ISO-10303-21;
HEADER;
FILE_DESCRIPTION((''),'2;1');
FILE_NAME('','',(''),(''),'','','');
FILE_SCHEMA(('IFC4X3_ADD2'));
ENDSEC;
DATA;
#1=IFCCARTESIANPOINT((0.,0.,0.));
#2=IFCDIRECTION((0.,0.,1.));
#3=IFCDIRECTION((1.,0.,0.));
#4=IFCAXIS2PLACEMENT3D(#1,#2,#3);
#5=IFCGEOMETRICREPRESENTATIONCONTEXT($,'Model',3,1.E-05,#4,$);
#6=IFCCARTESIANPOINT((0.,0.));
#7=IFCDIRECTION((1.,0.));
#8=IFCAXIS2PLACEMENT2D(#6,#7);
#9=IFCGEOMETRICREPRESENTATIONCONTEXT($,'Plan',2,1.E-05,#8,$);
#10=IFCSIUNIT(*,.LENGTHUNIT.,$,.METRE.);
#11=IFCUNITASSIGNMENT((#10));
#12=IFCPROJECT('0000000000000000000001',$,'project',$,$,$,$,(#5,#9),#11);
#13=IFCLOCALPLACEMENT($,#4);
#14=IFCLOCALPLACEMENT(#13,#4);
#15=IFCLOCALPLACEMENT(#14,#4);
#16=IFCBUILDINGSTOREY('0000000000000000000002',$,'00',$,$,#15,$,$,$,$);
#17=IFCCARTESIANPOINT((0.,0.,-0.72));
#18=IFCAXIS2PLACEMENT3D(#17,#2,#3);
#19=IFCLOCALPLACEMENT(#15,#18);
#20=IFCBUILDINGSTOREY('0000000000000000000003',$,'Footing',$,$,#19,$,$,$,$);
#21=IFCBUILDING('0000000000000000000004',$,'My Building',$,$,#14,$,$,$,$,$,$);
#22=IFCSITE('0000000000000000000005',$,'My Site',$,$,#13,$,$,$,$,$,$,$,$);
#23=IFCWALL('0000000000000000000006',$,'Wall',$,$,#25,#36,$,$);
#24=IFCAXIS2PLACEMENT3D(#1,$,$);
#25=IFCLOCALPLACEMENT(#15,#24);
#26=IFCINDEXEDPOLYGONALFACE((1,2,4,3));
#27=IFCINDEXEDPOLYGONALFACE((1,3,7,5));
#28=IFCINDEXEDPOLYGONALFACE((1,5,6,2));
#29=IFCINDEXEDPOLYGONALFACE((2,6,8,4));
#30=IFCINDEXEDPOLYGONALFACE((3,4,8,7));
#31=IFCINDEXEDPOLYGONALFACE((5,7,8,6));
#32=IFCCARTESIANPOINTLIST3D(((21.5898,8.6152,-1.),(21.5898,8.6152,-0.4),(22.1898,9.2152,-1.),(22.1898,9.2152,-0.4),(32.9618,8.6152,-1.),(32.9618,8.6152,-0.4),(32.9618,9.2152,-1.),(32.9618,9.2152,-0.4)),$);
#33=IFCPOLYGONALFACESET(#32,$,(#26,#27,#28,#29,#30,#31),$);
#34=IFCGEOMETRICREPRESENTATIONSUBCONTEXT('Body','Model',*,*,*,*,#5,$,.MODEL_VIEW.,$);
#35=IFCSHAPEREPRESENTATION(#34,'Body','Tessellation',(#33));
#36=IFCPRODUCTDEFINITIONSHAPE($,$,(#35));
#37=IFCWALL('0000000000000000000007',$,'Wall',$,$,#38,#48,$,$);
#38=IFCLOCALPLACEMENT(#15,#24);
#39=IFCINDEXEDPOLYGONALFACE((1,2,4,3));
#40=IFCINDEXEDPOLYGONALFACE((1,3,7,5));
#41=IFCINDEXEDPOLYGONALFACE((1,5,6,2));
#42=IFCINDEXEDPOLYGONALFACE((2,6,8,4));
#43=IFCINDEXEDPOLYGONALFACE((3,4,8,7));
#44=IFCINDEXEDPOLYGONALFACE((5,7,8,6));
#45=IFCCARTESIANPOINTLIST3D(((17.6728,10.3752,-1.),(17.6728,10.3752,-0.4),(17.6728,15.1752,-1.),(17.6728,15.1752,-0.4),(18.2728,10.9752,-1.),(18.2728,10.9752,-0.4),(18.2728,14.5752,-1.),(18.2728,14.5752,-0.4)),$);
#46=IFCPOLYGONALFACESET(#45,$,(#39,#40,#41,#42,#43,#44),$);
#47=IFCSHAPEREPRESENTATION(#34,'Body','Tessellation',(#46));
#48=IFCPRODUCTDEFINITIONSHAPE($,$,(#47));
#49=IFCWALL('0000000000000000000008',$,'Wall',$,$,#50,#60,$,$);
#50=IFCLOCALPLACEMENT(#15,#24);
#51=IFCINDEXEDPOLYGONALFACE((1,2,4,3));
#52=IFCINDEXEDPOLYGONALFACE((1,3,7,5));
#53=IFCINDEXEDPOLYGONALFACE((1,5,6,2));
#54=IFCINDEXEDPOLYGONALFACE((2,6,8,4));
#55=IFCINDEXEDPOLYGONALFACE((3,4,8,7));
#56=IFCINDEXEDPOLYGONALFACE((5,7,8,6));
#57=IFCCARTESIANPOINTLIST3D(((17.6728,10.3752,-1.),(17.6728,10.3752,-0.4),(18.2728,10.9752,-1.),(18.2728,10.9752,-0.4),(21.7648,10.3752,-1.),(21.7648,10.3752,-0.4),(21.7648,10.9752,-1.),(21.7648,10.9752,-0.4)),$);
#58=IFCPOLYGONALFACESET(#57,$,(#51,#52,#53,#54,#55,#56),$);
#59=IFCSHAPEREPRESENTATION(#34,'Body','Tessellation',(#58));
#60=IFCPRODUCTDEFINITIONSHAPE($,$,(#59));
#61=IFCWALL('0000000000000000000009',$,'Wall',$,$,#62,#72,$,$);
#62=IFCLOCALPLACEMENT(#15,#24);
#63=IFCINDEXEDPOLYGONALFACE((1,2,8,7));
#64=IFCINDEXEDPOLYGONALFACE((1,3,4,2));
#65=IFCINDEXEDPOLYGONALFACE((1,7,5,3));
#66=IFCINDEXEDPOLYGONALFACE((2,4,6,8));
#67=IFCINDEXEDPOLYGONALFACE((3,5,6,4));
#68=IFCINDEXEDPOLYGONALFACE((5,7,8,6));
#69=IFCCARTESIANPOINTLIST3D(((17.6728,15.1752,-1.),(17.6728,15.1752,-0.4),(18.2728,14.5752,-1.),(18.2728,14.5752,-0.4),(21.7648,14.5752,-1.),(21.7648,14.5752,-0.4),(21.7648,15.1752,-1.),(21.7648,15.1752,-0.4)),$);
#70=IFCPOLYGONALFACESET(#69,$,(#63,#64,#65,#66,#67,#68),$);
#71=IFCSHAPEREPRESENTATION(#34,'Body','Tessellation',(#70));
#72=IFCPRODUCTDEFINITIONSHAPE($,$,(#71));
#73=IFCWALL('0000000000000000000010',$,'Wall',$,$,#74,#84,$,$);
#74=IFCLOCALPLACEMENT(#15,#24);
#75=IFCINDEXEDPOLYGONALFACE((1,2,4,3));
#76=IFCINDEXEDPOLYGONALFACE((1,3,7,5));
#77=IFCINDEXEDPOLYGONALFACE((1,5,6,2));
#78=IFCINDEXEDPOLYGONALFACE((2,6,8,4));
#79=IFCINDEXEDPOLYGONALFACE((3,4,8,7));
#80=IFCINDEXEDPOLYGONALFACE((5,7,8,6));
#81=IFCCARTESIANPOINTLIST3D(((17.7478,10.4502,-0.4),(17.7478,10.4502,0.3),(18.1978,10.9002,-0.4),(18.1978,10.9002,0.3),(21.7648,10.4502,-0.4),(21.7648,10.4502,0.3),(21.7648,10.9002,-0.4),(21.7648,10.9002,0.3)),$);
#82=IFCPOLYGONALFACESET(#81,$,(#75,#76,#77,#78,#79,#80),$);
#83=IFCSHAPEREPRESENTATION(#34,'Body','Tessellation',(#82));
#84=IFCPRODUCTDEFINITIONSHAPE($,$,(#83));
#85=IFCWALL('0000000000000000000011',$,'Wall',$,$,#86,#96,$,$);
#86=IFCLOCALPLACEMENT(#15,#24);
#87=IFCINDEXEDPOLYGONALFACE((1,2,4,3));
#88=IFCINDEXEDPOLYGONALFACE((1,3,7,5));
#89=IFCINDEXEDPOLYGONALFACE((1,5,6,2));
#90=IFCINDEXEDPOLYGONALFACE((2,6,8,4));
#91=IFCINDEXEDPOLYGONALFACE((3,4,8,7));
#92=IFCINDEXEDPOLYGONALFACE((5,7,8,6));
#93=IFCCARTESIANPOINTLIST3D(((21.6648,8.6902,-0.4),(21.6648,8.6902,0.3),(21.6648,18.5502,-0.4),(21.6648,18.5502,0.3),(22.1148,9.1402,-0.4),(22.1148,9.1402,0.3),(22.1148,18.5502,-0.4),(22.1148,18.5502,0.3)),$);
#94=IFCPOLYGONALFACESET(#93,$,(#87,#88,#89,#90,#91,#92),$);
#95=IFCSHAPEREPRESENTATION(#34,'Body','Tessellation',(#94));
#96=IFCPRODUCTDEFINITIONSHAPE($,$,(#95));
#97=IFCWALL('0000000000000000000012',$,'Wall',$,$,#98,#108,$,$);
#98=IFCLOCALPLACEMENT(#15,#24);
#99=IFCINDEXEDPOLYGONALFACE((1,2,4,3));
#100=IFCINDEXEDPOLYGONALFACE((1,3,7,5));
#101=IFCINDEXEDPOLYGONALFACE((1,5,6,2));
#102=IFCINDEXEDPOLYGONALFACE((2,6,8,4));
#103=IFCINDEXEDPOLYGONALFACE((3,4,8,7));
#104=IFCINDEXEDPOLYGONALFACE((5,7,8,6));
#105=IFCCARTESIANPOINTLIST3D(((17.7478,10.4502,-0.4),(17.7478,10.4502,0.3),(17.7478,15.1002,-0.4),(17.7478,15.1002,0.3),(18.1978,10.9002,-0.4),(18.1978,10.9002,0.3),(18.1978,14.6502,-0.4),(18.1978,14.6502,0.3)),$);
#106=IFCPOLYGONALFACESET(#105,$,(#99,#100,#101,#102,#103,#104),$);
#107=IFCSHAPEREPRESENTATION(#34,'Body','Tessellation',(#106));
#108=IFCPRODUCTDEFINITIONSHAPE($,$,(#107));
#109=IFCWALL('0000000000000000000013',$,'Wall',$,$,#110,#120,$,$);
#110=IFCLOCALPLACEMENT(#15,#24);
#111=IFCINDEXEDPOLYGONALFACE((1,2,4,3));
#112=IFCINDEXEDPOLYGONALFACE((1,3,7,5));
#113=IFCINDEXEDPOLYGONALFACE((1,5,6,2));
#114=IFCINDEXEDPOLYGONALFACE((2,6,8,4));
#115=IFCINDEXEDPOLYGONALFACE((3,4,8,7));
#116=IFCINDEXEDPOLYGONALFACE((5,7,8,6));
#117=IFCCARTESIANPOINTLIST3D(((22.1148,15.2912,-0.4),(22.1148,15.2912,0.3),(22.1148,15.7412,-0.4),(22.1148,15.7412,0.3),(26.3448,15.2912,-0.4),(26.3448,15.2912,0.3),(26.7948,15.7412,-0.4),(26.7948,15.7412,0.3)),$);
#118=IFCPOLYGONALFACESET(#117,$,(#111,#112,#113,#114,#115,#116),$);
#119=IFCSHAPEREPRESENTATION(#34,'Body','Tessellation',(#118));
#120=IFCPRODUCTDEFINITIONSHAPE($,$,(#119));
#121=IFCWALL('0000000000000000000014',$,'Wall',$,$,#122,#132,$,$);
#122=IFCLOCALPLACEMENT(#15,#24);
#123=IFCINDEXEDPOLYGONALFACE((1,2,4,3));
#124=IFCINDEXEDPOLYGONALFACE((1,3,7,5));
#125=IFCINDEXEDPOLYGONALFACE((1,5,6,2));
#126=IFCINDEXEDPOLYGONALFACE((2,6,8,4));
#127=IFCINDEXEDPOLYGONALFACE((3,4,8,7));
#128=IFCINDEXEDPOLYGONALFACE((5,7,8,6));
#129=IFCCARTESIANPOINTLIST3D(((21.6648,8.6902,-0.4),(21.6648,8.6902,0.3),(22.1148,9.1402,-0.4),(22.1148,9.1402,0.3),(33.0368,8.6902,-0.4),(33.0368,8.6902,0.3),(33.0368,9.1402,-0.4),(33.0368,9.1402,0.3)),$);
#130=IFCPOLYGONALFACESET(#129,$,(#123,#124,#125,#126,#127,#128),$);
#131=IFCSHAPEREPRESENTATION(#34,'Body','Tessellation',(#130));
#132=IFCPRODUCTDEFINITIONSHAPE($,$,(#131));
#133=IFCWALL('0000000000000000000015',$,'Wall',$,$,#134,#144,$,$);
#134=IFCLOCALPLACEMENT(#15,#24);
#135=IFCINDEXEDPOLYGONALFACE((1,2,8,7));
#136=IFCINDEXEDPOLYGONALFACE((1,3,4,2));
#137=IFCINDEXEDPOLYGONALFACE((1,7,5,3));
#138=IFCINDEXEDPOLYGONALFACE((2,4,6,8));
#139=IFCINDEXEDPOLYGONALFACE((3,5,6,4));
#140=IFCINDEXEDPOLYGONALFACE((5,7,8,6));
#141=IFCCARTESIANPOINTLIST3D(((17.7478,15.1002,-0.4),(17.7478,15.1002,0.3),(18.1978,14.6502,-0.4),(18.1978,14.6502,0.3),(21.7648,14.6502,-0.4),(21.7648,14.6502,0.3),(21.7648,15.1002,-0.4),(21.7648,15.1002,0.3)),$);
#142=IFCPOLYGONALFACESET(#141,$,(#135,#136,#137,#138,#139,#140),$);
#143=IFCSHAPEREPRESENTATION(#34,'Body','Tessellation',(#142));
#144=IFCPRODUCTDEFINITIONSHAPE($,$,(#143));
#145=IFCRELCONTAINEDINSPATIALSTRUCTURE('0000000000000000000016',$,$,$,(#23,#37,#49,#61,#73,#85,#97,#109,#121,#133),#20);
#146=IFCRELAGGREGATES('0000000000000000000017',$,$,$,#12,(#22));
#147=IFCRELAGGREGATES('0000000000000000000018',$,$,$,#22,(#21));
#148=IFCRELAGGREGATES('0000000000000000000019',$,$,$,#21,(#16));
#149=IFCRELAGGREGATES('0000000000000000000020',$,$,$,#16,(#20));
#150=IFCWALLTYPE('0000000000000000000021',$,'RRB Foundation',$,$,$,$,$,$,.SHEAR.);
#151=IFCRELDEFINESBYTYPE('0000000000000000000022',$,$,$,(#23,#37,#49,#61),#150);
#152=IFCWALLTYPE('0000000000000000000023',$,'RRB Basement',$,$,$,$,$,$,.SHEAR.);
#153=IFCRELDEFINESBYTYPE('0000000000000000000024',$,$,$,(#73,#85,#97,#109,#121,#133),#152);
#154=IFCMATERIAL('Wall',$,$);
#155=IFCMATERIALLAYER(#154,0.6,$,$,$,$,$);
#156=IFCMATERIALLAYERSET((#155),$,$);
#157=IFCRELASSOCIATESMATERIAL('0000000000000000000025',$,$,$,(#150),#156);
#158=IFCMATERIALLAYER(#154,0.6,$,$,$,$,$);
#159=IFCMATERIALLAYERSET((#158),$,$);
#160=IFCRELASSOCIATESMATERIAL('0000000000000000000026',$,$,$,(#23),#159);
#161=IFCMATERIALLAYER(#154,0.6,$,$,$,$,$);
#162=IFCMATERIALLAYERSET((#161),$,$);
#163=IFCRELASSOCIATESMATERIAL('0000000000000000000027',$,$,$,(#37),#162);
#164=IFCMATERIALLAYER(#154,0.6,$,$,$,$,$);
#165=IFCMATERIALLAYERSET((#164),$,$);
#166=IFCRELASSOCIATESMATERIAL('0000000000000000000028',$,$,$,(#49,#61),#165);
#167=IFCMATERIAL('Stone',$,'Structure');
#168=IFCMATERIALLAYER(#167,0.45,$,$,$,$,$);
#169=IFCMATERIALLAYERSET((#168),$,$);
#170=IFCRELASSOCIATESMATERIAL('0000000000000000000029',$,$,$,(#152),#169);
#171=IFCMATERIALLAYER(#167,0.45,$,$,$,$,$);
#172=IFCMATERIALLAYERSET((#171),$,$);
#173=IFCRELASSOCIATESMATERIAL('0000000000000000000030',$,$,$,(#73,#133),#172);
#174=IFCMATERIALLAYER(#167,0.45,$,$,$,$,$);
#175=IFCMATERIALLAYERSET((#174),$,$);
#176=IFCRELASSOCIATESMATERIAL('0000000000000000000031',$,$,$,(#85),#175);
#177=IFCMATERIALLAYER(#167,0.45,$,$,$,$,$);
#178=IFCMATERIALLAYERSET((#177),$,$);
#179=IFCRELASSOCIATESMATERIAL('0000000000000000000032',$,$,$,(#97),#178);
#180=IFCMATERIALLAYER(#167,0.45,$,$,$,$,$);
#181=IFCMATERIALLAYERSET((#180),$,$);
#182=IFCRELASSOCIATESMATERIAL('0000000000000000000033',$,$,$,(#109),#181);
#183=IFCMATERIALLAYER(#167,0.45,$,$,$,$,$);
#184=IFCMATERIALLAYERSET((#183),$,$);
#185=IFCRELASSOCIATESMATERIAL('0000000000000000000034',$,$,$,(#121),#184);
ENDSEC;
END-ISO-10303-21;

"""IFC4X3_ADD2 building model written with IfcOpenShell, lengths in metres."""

from ifc_helpers import new_model, si_unit, frame, origin_with_axes, origin_2d_with_axis, place, context, subcontext, project, spatial, line, indexed_curve, outline, extrude, material, layer, layer_set, layer_usage, type_object, element, save


model = new_model("IFC4X3_ADD2")

# Units and contexts
model_context = context("Model", 3, precision=1e-05, world=origin_with_axes())
plan_context = context("Plan", 2, precision=1e-05, world=origin_2d_with_axis())
body_context = subcontext(model_context, "Body", "Model", "MODEL_VIEW")
ifc_project = project(units=[si_unit("LENGTHUNIT", "METRE")], contexts=[model_context, plan_context])

# Site, building, storeys
site_placement = place(None, origin_with_axes())
site = spatial("IfcSite", under=ifc_project, at=site_placement, Name="My Site")
building_placement = place(site_placement, origin_with_axes())
building = spatial("IfcBuilding", under=site, at=building_placement, Name="My Building")
storey_1_placement = place(building_placement, origin_with_axes())
storey_1 = spatial("IfcBuildingStorey", under=building, at=storey_1_placement, Name="00")
storey_2_placement = place(storey_1_placement, frame((0.0, 0.0, -0.72), z_axis=(0.0, 0.0, 1.0), x_axis=(1.0, 0.0, 0.0)))
storey_2 = spatial("IfcBuildingStorey", under=storey_1, at=storey_2_placement, Name="Footing")

# Shared definitions
ifc_material_1 = material(Name="Wall")

# Walls
ifc_layer_1 = layer(ifc_material_1, 0.6)
ifc_layer_set_1 = layer_set([ifc_layer_1])
wall_type_1 = type_object("IfcWallType", Name="RRB Foundation", PredefinedType="SHEAR", material=ifc_layer_set_1)
ifc_layer_2 = layer(ifc_material_1, 0.6)
ifc_layer_set_2 = layer_set([ifc_layer_2])
ifc_layer_usage_1 = layer_usage(ifc_layer_set_2, "AXIS2", "POSITIVE", 0.0)
wall_1_placement = place(storey_2_placement, frame((22.1898, 8.6152, -0.28), z_axis=(0.0, 0.0, 1.0), x_axis=(1.0, 0.0, 0.0)))
element("IfcWall", 1, at=wall_1_placement, inside=storey_2, type_object=wall_type_1, material=ifc_layer_usage_1, Name="Wall", context=body_context, shape_type="SweptSolid", body=[
    extrude(outline(indexed_curve([(-0.6, 0.0), (0.0, 0.6), (10.772, 0.6), (10.772, 0.0)], segments=[line(1, 2, 3, 4, 1)])), origin_with_axes(), (0.0, 0.0, 1.0), 0.6),
])
ifc_layer_3 = layer(ifc_material_1, 0.6)
ifc_layer_set_3 = layer_set([ifc_layer_3])
ifc_layer_usage_2 = layer_usage(ifc_layer_set_3, "AXIS2", "POSITIVE", 0.0)
wall_2_placement = place(storey_2_placement, frame((18.2728, 10.3752, -0.28), z_axis=(0.0, 0.0, 1.0), x_axis=(0.0, 1.0, 0.0)))
element("IfcWall", 2, at=wall_2_placement, inside=storey_2, type_object=wall_type_1, material=ifc_layer_usage_2, Name="Wall", context=body_context, shape_type="SweptSolid", body=[
    extrude(outline(indexed_curve([(0.6, 0.0), (0.0, 0.6), (4.8, 0.6), (4.2, 0.0)], segments=[line(1, 2, 3, 4, 1)])), origin_with_axes(), (0.0, 0.0, 1.0), 0.6),
])
ifc_layer_4 = layer(ifc_material_1, 0.6)
ifc_layer_set_4 = layer_set([ifc_layer_4])
ifc_layer_usage_3 = layer_usage(ifc_layer_set_4, "AXIS2", "POSITIVE", 0.0)
wall_3_placement = place(storey_2_placement, frame((18.2728, 10.3752, -0.28), z_axis=(0.0, 0.0, 1.0), x_axis=(1.0, 0.0, 0.0)))
element("IfcWall", 3, at=wall_3_placement, inside=storey_2, type_object=wall_type_1, material=ifc_layer_usage_3, Name="Wall", context=body_context, shape_type="SweptSolid", body=[
    extrude(outline(indexed_curve([(-0.6, 0.0), (0.0, 0.6), (3.492, 0.6), (3.492, 0.0)], segments=[line(1, 2, 3, 4, 1)])), origin_with_axes(), (0.0, 0.0, 1.0), 0.6),
])
ifc_layer_usage_4 = layer_usage(ifc_layer_set_4, "AXIS2", "POSITIVE", 0.0)
wall_4_placement = place(storey_2_placement, frame((18.2728, 14.5752, -0.28), z_axis=(0.0, 0.0, 1.0), x_axis=(1.0, 0.0, 0.0)))
element("IfcWall", 4, at=wall_4_placement, inside=storey_2, type_object=wall_type_1, material=ifc_layer_usage_4, Name="Wall", context=body_context, shape_type="SweptSolid", body=[
    extrude(outline(indexed_curve([(0.0, 0.0), (-0.6, 0.6), (3.492, 0.6), (3.492, 0.0)], segments=[line(1, 2, 3, 4, 1)])), origin_with_axes(), (0.0, 0.0, 1.0), 0.6),
])
ifc_material_2 = material(Name="Stone", Category="Structure")
ifc_layer_5 = layer(ifc_material_2, 0.45)
ifc_layer_set_5 = layer_set([ifc_layer_5])
ifc_layer_usage_5 = layer_usage(ifc_layer_set_5, "AXIS2", "POSITIVE", 0.0)
ifc_layer_6 = layer(ifc_material_2, 0.45)
ifc_layer_set_6 = layer_set([ifc_layer_6])
wall_type_2 = type_object("IfcWallType", Name="RRB Basement", PredefinedType="SHEAR", material=ifc_layer_set_6)
wall_5_placement = place(storey_2_placement, frame((18.1978, 10.4502, 0.32), z_axis=(0.0, 0.0, 1.0), x_axis=(1.0, 0.0, 0.0)))
element("IfcWall", 5, at=wall_5_placement, inside=storey_2, type_object=wall_type_2, material=ifc_layer_usage_5, Name="Wall", context=body_context, shape_type="SweptSolid", body=[
    extrude(outline(indexed_curve([(-0.45, 0.0), (0.0, 0.45), (3.567, 0.45), (3.567, 0.0)], segments=[line(1, 2, 3, 4, 1)])), origin_with_axes(), (0.0, 0.0, 1.0), 0.7),
])
ifc_layer_7 = layer(ifc_material_2, 0.45)
ifc_layer_set_7 = layer_set([ifc_layer_7])
ifc_layer_usage_6 = layer_usage(ifc_layer_set_7, "AXIS2", "POSITIVE", 0.0)
wall_6_placement = place(storey_2_placement, frame((22.1148, 8.6902, 0.32), z_axis=(0.0, 0.0, 1.0), x_axis=(0.0, 1.0, 0.0)))
element("IfcWall", 6, at=wall_6_placement, inside=storey_2, type_object=wall_type_2, material=ifc_layer_usage_6, Name="Wall", context=body_context, shape_type="SweptSolid", body=[
    extrude(outline(indexed_curve([(0.45, 0.0), (0.0, 0.45), (9.86, 0.45), (9.86, 0.0)], segments=[line(1, 2, 3, 4, 1)])), origin_with_axes(), (0.0, 0.0, 1.0), 0.7),
])
ifc_layer_8 = layer(ifc_material_2, 0.45)
ifc_layer_set_8 = layer_set([ifc_layer_8])
ifc_layer_usage_7 = layer_usage(ifc_layer_set_8, "AXIS2", "POSITIVE", 0.0)
wall_7_placement = place(storey_2_placement, frame((18.1978, 10.4502, 0.32), z_axis=(0.0, 0.0, 1.0), x_axis=(0.0, 1.0, 0.0)))
element("IfcWall", 7, at=wall_7_placement, inside=storey_2, type_object=wall_type_2, material=ifc_layer_usage_7, Name="Wall", context=body_context, shape_type="SweptSolid", body=[
    extrude(outline(indexed_curve([(0.45, 0.0), (0.0, 0.45), (4.65, 0.45), (4.2, 0.0)], segments=[line(1, 2, 3, 4, 1)])), origin_with_axes(), (0.0, 0.0, 1.0), 0.7),
])
ifc_layer_9 = layer(ifc_material_2, 0.45)
ifc_layer_set_9 = layer_set([ifc_layer_9])
ifc_layer_usage_8 = layer_usage(ifc_layer_set_9, "AXIS2", "POSITIVE", 0.0)
wall_8_placement = place(storey_2_placement, frame((22.1148, 15.2912, 0.32), z_axis=(0.0, 0.0, 1.0), x_axis=(1.0, 0.0, 0.0)))
element("IfcWall", 8, at=wall_8_placement, inside=storey_2, type_object=wall_type_2, material=ifc_layer_usage_8, Name="Wall", context=body_context, shape_type="SweptSolid", body=[
    extrude(outline(indexed_curve([(0.0, 0.0), (0.0, 0.45), (4.68, 0.45), (4.23, 0.0)], segments=[line(1, 2, 3, 4, 1)])), origin_with_axes(), (0.0, 0.0, 1.0), 0.7),
])
ifc_layer_10 = layer(ifc_material_2, 0.45)
ifc_layer_set_10 = layer_set([ifc_layer_10])
ifc_layer_usage_9 = layer_usage(ifc_layer_set_10, "AXIS2", "POSITIVE", 0.0)
wall_9_placement = place(storey_2_placement, frame((22.1148, 8.6902, 0.32), z_axis=(0.0, 0.0, 1.0), x_axis=(1.0, 0.0, 0.0)))
element("IfcWall", 9, at=wall_9_placement, inside=storey_2, type_object=wall_type_2, material=ifc_layer_usage_9, Name="Wall", context=body_context, shape_type="SweptSolid", body=[
    extrude(outline(indexed_curve([(-0.45, 0.0), (0.0, 0.45), (10.922, 0.45), (10.922, 0.0)], segments=[line(1, 2, 3, 4, 1)])), origin_with_axes(), (0.0, 0.0, 1.0), 0.7),
])
ifc_layer_usage_10 = layer_usage(ifc_layer_set_5, "AXIS2", "POSITIVE", 0.0)
wall_10_placement = place(storey_2_placement, frame((18.1978, 14.6502, 0.32), z_axis=(0.0, 0.0, 1.0), x_axis=(1.0, 0.0, 0.0)))
element("IfcWall", 10, at=wall_10_placement, inside=storey_2, type_object=wall_type_2, material=ifc_layer_usage_10, Name="Wall", context=body_context, shape_type="SweptSolid", body=[
    extrude(outline(indexed_curve([(0.0, 0.0), (-0.45, 0.45), (3.567, 0.45), (3.567, 0.0)], segments=[line(1, 2, 3, 4, 1)])), origin_with_axes(), (0.0, 0.0, 1.0), 0.7),
])

save(model, "model.ifc")
